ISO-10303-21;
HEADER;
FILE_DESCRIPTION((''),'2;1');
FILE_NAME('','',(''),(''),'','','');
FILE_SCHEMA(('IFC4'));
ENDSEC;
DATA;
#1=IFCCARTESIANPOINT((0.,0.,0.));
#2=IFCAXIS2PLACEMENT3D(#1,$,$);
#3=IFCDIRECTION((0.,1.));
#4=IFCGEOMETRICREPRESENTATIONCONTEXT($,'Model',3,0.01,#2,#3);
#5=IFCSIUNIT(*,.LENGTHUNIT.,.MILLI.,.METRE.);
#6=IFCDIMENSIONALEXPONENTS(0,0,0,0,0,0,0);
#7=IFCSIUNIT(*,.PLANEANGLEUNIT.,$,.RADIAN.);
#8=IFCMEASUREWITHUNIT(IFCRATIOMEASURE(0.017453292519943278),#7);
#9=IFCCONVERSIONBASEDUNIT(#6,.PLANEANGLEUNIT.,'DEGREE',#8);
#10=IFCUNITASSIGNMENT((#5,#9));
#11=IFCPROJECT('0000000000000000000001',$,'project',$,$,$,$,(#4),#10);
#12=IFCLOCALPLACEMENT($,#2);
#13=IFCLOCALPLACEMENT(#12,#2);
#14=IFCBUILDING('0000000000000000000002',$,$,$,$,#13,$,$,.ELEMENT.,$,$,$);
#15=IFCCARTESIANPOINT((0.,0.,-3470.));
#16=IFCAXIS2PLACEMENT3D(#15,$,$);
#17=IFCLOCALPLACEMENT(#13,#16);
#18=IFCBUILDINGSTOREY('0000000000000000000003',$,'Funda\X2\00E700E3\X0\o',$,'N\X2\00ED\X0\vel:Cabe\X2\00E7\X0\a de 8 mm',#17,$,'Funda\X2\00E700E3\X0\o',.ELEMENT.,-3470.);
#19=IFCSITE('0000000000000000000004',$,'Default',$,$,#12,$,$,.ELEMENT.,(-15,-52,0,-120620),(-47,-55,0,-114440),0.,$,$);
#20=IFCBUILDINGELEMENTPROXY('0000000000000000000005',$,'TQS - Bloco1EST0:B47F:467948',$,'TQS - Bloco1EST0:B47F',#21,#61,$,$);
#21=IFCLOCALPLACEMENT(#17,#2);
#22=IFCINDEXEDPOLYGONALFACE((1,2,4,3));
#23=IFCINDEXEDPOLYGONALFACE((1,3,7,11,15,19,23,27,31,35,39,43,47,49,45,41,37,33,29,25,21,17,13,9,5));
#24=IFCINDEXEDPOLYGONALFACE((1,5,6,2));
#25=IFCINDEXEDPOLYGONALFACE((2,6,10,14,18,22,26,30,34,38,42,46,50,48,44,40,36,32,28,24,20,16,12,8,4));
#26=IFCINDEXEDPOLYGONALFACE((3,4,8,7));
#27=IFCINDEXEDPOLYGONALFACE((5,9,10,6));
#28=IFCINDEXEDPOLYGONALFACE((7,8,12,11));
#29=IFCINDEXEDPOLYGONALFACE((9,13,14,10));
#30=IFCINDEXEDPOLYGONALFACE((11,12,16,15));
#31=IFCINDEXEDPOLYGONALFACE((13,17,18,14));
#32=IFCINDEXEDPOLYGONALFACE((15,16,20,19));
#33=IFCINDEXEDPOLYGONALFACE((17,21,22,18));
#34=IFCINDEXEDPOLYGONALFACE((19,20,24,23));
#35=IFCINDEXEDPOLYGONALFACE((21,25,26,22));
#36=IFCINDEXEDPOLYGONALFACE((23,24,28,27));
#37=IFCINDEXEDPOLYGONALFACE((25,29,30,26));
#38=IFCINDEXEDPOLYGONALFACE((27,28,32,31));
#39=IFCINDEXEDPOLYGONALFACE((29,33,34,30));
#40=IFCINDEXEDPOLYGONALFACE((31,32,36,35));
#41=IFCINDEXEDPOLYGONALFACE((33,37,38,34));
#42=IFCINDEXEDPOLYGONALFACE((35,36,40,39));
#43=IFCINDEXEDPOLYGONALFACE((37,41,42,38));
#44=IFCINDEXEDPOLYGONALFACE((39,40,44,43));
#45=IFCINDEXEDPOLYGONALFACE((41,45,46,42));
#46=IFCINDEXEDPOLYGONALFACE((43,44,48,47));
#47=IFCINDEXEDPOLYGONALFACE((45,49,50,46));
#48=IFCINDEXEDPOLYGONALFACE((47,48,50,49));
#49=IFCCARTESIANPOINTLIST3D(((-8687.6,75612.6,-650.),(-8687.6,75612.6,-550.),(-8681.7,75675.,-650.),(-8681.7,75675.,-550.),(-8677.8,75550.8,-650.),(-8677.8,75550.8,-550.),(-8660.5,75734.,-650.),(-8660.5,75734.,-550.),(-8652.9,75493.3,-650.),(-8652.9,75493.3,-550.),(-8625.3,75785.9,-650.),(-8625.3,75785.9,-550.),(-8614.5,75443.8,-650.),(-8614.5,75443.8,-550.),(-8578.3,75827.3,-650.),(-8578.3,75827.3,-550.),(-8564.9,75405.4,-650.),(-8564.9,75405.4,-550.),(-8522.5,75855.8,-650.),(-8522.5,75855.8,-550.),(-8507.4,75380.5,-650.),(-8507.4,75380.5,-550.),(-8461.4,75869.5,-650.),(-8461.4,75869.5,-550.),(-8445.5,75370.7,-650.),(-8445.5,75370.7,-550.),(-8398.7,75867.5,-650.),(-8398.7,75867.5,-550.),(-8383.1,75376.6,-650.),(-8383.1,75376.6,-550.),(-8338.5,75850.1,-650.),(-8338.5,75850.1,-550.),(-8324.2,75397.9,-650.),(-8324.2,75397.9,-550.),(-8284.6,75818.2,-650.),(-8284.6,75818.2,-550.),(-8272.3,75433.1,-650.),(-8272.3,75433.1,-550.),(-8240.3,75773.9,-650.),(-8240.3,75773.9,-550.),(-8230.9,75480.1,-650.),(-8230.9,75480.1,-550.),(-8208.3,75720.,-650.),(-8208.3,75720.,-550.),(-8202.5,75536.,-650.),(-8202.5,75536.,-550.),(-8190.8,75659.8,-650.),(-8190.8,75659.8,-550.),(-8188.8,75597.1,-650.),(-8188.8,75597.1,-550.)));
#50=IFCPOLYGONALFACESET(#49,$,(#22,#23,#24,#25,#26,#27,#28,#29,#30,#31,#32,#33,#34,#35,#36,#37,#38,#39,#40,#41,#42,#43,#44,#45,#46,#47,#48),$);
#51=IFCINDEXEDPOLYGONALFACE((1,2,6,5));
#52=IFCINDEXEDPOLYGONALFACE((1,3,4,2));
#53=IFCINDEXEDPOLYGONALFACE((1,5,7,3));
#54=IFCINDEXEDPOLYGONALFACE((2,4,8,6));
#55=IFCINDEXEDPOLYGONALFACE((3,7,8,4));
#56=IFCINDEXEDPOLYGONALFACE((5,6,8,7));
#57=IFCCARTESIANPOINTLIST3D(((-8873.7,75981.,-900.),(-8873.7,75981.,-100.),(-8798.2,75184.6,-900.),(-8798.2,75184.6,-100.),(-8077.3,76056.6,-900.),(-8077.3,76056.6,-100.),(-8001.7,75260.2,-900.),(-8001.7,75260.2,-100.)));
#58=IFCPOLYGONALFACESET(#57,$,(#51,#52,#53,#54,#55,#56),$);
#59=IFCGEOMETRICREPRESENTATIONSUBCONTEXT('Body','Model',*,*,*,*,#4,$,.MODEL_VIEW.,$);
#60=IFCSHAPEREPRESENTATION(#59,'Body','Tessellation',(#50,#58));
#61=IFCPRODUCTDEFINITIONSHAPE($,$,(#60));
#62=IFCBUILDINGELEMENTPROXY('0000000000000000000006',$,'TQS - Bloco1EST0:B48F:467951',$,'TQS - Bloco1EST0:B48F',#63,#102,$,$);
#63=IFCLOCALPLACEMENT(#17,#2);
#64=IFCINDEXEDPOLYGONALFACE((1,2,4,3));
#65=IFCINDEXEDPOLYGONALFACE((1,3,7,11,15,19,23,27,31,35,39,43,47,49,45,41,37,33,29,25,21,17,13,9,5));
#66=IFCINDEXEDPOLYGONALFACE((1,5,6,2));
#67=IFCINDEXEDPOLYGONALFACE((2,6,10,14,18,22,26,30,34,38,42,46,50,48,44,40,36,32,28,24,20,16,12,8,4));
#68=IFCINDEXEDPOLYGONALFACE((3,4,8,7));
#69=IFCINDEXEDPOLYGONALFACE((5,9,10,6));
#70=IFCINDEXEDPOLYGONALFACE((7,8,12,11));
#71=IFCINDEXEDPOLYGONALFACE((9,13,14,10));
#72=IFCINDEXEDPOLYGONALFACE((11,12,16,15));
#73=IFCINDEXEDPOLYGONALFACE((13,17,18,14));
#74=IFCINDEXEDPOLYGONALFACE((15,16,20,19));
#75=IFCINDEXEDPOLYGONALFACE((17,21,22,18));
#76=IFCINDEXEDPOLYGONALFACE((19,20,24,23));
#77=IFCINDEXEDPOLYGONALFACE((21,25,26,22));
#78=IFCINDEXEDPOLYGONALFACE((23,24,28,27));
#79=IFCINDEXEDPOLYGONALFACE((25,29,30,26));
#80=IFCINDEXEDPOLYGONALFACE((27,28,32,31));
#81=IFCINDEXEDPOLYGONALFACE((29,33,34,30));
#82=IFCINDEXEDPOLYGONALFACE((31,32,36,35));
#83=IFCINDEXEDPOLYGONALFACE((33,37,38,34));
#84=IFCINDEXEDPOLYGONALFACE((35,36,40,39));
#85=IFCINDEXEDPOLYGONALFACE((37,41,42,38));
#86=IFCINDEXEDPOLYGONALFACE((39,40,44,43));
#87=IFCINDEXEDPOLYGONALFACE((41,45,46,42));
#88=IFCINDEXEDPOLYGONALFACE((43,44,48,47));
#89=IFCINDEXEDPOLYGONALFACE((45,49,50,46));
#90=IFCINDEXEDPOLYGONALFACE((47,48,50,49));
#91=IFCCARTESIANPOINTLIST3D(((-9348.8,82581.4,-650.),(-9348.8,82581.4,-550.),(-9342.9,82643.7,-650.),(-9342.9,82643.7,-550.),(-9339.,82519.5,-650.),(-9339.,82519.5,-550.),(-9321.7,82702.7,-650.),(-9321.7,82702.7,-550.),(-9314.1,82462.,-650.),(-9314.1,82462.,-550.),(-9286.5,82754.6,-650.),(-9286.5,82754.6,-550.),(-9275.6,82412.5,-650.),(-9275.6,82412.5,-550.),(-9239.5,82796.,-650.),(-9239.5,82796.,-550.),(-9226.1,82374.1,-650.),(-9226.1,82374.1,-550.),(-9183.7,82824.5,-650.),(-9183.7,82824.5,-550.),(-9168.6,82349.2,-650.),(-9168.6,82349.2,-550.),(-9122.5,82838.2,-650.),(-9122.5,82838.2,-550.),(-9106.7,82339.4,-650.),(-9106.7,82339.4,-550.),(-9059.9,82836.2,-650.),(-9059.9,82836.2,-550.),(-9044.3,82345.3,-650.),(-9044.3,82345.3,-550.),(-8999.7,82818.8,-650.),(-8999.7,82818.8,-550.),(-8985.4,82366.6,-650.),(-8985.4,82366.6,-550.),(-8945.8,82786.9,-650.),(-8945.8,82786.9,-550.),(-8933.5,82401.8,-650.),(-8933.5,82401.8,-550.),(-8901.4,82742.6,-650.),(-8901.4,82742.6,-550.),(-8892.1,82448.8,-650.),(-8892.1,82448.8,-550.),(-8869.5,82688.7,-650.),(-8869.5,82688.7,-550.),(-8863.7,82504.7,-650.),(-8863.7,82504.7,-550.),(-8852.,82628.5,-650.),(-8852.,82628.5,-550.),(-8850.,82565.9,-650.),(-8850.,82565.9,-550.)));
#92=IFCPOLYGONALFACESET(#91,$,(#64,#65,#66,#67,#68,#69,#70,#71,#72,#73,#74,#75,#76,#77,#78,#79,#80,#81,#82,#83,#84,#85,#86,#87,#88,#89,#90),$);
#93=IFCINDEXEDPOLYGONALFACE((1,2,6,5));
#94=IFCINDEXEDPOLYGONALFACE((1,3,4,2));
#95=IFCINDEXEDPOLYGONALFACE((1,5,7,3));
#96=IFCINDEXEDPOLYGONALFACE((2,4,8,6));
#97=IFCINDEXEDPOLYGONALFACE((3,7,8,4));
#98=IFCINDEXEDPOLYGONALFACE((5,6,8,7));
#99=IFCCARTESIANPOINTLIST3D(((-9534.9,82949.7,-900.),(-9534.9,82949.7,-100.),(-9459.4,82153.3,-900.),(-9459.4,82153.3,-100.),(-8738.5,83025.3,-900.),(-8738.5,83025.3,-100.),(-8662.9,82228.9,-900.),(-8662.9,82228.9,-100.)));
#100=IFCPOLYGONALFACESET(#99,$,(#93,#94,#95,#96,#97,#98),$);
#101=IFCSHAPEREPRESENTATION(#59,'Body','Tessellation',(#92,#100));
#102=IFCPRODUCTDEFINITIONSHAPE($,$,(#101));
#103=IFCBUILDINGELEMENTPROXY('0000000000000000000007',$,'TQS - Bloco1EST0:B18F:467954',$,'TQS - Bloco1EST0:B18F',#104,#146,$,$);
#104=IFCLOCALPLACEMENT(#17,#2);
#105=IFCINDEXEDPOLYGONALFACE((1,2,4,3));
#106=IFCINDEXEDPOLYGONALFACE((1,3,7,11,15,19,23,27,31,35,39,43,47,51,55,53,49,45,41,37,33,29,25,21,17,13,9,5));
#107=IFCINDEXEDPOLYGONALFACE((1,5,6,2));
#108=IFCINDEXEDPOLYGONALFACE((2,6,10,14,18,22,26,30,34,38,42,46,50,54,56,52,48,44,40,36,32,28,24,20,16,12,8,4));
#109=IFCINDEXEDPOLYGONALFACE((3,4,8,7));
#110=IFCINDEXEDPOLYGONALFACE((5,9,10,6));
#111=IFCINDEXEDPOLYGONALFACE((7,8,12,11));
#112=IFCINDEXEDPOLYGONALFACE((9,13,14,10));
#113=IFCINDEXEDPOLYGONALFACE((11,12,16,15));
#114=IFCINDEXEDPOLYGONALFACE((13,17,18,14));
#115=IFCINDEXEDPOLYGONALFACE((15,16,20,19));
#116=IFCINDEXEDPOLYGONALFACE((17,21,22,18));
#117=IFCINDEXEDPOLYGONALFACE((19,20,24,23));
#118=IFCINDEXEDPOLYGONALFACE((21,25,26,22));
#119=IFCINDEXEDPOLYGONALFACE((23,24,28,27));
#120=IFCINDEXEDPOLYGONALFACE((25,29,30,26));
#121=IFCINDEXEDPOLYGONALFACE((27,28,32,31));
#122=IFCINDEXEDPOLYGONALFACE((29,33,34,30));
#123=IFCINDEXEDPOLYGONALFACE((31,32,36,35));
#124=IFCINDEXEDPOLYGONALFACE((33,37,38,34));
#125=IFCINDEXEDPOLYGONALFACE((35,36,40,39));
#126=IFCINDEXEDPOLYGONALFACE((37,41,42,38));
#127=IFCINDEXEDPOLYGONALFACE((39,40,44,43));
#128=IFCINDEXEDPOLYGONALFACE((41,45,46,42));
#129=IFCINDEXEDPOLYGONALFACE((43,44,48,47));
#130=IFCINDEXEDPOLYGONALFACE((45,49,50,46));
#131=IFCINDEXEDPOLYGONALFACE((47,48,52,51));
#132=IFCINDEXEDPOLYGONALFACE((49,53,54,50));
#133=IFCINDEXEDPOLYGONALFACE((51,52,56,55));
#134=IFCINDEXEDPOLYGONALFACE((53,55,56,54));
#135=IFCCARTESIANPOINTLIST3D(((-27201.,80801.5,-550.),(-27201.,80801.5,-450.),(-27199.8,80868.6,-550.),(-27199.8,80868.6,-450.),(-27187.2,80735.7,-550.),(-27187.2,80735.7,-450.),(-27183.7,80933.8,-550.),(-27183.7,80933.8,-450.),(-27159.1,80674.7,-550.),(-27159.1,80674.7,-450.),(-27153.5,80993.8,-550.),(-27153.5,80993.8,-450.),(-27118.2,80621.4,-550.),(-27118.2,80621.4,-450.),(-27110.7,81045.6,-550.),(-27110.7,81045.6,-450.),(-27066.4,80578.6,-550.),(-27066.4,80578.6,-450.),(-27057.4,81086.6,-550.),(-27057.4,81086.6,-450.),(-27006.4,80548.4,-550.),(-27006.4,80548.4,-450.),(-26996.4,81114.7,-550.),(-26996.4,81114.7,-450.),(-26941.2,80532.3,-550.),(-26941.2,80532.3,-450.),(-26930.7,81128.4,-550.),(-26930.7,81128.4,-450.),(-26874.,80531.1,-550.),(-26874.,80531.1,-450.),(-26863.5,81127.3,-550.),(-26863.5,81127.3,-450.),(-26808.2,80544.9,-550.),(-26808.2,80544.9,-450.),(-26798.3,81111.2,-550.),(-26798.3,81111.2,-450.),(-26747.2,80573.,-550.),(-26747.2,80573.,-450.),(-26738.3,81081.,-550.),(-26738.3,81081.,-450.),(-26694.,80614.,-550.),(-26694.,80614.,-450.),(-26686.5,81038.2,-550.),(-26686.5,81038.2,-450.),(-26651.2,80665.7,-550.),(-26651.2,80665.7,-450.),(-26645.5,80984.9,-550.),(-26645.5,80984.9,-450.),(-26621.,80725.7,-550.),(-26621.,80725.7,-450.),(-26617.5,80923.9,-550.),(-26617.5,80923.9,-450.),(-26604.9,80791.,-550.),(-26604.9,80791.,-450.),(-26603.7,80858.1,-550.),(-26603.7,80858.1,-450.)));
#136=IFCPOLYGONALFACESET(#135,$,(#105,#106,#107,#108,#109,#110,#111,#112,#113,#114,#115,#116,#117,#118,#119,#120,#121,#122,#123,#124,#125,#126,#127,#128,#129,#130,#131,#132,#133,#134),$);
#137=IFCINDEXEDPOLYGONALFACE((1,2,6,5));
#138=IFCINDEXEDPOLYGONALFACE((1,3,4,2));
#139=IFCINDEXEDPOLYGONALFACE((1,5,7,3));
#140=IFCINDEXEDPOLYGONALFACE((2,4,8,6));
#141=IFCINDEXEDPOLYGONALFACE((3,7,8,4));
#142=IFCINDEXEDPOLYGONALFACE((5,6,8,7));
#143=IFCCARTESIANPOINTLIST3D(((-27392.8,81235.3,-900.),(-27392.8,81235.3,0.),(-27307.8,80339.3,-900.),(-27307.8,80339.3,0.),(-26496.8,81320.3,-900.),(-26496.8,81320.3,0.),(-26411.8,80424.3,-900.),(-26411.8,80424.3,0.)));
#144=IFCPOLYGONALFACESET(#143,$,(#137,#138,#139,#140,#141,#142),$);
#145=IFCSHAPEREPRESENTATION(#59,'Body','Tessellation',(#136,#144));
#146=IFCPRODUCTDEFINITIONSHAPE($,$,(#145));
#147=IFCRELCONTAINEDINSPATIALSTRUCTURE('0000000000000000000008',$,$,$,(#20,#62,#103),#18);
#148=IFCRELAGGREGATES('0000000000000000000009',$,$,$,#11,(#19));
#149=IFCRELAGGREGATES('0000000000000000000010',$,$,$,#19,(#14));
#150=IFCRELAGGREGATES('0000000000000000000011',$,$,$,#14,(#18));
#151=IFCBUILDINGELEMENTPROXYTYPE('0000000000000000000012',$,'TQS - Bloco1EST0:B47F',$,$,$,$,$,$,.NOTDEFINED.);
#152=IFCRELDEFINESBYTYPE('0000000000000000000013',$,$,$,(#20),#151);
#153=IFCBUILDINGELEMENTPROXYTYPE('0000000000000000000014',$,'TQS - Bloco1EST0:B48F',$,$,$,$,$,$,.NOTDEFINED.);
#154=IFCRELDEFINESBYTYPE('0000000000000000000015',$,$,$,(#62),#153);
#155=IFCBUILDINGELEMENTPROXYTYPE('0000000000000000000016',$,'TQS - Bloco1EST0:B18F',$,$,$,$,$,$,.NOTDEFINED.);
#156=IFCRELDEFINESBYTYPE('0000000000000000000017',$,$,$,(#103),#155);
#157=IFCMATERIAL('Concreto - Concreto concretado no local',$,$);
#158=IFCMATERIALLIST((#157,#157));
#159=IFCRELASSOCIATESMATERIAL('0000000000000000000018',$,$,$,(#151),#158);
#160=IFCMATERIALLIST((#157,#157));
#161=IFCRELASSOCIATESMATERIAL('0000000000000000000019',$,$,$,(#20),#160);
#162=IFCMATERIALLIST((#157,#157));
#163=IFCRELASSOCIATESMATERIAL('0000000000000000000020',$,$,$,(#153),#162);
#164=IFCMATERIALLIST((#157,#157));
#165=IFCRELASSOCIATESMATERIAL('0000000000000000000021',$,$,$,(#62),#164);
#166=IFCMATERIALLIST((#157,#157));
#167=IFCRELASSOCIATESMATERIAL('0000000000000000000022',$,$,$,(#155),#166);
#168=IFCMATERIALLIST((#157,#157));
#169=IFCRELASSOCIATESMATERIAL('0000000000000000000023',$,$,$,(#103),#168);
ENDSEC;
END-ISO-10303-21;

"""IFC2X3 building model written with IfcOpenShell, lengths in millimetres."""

from ifc_helpers import new_model, entity, si_unit, converted_unit, direction, frame, frame_2d, origin, origin_2d_with_axis, place, context, subcontext, project, spatial, rectangle, circle, extrude, source, transform, mapped, material, material_list, type_object, type_shapes, element, save


model = new_model("IFC2X3")

# Units and contexts
model_context = context("Model", 3, precision=0.01, world=origin(), true_north=direction((0.0, 1.0)))
body_context = subcontext(model_context, "Body", "Model", "MODEL_VIEW")
ifc_project = project(units=[si_unit("LENGTHUNIT", "METRE", prefix="MILLI"), converted_unit("PLANEANGLEUNIT", "DEGREE", entity("IfcRatioMeasure", 0.017453292519943278), si_unit("PLANEANGLEUNIT", "RADIAN"), dimensions=[0, 0, 0, 0, 0, 0, 0])], contexts=[model_context])

# Site, building, storey
site_placement = place(None, origin())
site = spatial("IfcSite", under=ifc_project, at=site_placement, Name="Default", CompositionType="ELEMENT", RefLatitude=(-15, -52, 0, -120620), RefLongitude=(-47, -55, 0, -114440), RefElevation=0.0)
building_placement = place(site_placement, origin())
building = spatial("IfcBuilding", under=site, at=building_placement, CompositionType="ELEMENT")
storey_placement = place(building_placement, frame((0.0, 0.0, -3470.0)))
storey = spatial("IfcBuildingStorey", under=building, at=storey_placement, Name="Fundação", ObjectType="Nível:Cabeça de 8 mm", LongName="Fundação", CompositionType="ELEMENT", Elevation=-3470.0)

# Building element proxies
ifc_material_1 = material(Name="Concreto - Concreto concretado no local")
ifc_material_list_1 = material_list([ifc_material_1, ifc_material_1])
ifc_material_list_2 = material_list([ifc_material_1, ifc_material_1])
building_element_proxy_type_1 = type_object("IfcBuildingElementProxyType", Name="TQS - Bloco1EST0:B47F", PredefinedType="NOTDEFINED", material=ifc_material_list_2)
shared_shape_1 = source(origin(), body_context, "Body", "SweptSolid", [
    extrude(circle(Radius=250.0, at=frame_2d((0.0, 0.0), x_axis=(1.0, 0.0))), frame((0.0, 0.0, -550.0)), (0.0, 0.0, 1.0), 100.0),
    extrude(rectangle(XDim=800.0, YDim=800.0, at=origin_2d_with_axis()), frame((0.0, 0.0, -800.0), z_axis=(0.0, 0.0, 1.0), x_axis=(-1.0, 0.0, 0.0)), (0.0, 0.0, 1.0), 800.0),
])
type_shapes(building_element_proxy_type_1, [shared_shape_1])
proxy_1_placement = place(storey_placement, frame((-8437.7, 75620.6, -100.0), z_axis=(0.0, 0.0, 1.0), x_axis=(-0.094456, 0.995529, 0.0)))
element("IfcBuildingElementProxy", 1, at=proxy_1_placement, inside=storey, type_object=building_element_proxy_type_1, material=ifc_material_list_1, Name="TQS - Bloco1EST0:B47F:467948", ObjectType="TQS - Bloco1EST0:B47F", context=body_context, shape_type="MappedRepresentation", body=[
    mapped(shared_shape_1, transform((0.0, 0.0, 0.0), scale=1.0)),
])
ifc_material_list_3 = material_list([ifc_material_1, ifc_material_1])
ifc_material_list_4 = material_list([ifc_material_1, ifc_material_1])
building_element_proxy_type_2 = type_object("IfcBuildingElementProxyType", Name="TQS - Bloco1EST0:B48F", PredefinedType="NOTDEFINED", material=ifc_material_list_4)
shared_shape_2 = source(origin(), body_context, "Body", "SweptSolid", [
    extrude(circle(Radius=250.0, at=frame_2d((0.0, 0.0), x_axis=(1.0, 0.0))), frame((0.0, 0.0, -550.0)), (0.0, 0.0, 1.0), 100.0),
    extrude(rectangle(XDim=800.0, YDim=800.0, at=origin_2d_with_axis()), frame((0.0, 0.0, -800.0), z_axis=(0.0, 0.0, 1.0), x_axis=(-1.0, 0.0, 0.0)), (0.0, 0.0, 1.0), 800.0),
])
type_shapes(building_element_proxy_type_2, [shared_shape_2])
proxy_2_placement = place(storey_placement, frame((-9098.9, 82589.3, -100.0), z_axis=(0.0, 0.0, 1.0), x_axis=(-0.094456, 0.995529, 0.0)))
element("IfcBuildingElementProxy", 2, at=proxy_2_placement, inside=storey, type_object=building_element_proxy_type_2, material=ifc_material_list_3, Name="TQS - Bloco1EST0:B48F:467951", ObjectType="TQS - Bloco1EST0:B48F", context=body_context, shape_type="MappedRepresentation", body=[
    mapped(shared_shape_2, transform((0.0, 0.0, 0.0), scale=1.0)),
])
ifc_material_list_5 = material_list([ifc_material_1, ifc_material_1])
ifc_material_list_6 = material_list([ifc_material_1, ifc_material_1])
building_element_proxy_type_3 = type_object("IfcBuildingElementProxyType", Name="TQS - Bloco1EST0:B18F", PredefinedType="NOTDEFINED", material=ifc_material_list_6)
shared_shape_3 = source(origin(), body_context, "Body", "SweptSolid", [
    extrude(circle(Radius=300.0, at=frame_2d((0.0, 0.0), x_axis=(1.0, 0.0))), frame((0.0, 0.0, -550.0)), (0.0, 0.0, 1.0), 100.0),
    extrude(rectangle(XDim=900.0, YDim=900.0, at=origin_2d_with_axis()), frame((0.0, 0.0, -900.0), z_axis=(0.0, 0.0, 1.0), x_axis=(-1.0, 0.0, 0.0)), (0.0, 0.0, 1.0), 900.0),
])
type_shapes(building_element_proxy_type_3, [shared_shape_3])
proxy_3_placement = place(storey_placement, frame((-26902.3, 80829.8, 0.0), z_axis=(0.0, 0.0, 1.0), x_axis=(-0.094456, 0.995529, 0.0)))
element("IfcBuildingElementProxy", 3, at=proxy_3_placement, inside=storey, type_object=building_element_proxy_type_3, material=ifc_material_list_5, Name="TQS - Bloco1EST0:B18F:467954", ObjectType="TQS - Bloco1EST0:B18F", context=body_context, shape_type="MappedRepresentation", body=[
    mapped(shared_shape_3, transform((0.0, 0.0, 0.0), scale=1.0)),
])

save(model, "model.ifc")
